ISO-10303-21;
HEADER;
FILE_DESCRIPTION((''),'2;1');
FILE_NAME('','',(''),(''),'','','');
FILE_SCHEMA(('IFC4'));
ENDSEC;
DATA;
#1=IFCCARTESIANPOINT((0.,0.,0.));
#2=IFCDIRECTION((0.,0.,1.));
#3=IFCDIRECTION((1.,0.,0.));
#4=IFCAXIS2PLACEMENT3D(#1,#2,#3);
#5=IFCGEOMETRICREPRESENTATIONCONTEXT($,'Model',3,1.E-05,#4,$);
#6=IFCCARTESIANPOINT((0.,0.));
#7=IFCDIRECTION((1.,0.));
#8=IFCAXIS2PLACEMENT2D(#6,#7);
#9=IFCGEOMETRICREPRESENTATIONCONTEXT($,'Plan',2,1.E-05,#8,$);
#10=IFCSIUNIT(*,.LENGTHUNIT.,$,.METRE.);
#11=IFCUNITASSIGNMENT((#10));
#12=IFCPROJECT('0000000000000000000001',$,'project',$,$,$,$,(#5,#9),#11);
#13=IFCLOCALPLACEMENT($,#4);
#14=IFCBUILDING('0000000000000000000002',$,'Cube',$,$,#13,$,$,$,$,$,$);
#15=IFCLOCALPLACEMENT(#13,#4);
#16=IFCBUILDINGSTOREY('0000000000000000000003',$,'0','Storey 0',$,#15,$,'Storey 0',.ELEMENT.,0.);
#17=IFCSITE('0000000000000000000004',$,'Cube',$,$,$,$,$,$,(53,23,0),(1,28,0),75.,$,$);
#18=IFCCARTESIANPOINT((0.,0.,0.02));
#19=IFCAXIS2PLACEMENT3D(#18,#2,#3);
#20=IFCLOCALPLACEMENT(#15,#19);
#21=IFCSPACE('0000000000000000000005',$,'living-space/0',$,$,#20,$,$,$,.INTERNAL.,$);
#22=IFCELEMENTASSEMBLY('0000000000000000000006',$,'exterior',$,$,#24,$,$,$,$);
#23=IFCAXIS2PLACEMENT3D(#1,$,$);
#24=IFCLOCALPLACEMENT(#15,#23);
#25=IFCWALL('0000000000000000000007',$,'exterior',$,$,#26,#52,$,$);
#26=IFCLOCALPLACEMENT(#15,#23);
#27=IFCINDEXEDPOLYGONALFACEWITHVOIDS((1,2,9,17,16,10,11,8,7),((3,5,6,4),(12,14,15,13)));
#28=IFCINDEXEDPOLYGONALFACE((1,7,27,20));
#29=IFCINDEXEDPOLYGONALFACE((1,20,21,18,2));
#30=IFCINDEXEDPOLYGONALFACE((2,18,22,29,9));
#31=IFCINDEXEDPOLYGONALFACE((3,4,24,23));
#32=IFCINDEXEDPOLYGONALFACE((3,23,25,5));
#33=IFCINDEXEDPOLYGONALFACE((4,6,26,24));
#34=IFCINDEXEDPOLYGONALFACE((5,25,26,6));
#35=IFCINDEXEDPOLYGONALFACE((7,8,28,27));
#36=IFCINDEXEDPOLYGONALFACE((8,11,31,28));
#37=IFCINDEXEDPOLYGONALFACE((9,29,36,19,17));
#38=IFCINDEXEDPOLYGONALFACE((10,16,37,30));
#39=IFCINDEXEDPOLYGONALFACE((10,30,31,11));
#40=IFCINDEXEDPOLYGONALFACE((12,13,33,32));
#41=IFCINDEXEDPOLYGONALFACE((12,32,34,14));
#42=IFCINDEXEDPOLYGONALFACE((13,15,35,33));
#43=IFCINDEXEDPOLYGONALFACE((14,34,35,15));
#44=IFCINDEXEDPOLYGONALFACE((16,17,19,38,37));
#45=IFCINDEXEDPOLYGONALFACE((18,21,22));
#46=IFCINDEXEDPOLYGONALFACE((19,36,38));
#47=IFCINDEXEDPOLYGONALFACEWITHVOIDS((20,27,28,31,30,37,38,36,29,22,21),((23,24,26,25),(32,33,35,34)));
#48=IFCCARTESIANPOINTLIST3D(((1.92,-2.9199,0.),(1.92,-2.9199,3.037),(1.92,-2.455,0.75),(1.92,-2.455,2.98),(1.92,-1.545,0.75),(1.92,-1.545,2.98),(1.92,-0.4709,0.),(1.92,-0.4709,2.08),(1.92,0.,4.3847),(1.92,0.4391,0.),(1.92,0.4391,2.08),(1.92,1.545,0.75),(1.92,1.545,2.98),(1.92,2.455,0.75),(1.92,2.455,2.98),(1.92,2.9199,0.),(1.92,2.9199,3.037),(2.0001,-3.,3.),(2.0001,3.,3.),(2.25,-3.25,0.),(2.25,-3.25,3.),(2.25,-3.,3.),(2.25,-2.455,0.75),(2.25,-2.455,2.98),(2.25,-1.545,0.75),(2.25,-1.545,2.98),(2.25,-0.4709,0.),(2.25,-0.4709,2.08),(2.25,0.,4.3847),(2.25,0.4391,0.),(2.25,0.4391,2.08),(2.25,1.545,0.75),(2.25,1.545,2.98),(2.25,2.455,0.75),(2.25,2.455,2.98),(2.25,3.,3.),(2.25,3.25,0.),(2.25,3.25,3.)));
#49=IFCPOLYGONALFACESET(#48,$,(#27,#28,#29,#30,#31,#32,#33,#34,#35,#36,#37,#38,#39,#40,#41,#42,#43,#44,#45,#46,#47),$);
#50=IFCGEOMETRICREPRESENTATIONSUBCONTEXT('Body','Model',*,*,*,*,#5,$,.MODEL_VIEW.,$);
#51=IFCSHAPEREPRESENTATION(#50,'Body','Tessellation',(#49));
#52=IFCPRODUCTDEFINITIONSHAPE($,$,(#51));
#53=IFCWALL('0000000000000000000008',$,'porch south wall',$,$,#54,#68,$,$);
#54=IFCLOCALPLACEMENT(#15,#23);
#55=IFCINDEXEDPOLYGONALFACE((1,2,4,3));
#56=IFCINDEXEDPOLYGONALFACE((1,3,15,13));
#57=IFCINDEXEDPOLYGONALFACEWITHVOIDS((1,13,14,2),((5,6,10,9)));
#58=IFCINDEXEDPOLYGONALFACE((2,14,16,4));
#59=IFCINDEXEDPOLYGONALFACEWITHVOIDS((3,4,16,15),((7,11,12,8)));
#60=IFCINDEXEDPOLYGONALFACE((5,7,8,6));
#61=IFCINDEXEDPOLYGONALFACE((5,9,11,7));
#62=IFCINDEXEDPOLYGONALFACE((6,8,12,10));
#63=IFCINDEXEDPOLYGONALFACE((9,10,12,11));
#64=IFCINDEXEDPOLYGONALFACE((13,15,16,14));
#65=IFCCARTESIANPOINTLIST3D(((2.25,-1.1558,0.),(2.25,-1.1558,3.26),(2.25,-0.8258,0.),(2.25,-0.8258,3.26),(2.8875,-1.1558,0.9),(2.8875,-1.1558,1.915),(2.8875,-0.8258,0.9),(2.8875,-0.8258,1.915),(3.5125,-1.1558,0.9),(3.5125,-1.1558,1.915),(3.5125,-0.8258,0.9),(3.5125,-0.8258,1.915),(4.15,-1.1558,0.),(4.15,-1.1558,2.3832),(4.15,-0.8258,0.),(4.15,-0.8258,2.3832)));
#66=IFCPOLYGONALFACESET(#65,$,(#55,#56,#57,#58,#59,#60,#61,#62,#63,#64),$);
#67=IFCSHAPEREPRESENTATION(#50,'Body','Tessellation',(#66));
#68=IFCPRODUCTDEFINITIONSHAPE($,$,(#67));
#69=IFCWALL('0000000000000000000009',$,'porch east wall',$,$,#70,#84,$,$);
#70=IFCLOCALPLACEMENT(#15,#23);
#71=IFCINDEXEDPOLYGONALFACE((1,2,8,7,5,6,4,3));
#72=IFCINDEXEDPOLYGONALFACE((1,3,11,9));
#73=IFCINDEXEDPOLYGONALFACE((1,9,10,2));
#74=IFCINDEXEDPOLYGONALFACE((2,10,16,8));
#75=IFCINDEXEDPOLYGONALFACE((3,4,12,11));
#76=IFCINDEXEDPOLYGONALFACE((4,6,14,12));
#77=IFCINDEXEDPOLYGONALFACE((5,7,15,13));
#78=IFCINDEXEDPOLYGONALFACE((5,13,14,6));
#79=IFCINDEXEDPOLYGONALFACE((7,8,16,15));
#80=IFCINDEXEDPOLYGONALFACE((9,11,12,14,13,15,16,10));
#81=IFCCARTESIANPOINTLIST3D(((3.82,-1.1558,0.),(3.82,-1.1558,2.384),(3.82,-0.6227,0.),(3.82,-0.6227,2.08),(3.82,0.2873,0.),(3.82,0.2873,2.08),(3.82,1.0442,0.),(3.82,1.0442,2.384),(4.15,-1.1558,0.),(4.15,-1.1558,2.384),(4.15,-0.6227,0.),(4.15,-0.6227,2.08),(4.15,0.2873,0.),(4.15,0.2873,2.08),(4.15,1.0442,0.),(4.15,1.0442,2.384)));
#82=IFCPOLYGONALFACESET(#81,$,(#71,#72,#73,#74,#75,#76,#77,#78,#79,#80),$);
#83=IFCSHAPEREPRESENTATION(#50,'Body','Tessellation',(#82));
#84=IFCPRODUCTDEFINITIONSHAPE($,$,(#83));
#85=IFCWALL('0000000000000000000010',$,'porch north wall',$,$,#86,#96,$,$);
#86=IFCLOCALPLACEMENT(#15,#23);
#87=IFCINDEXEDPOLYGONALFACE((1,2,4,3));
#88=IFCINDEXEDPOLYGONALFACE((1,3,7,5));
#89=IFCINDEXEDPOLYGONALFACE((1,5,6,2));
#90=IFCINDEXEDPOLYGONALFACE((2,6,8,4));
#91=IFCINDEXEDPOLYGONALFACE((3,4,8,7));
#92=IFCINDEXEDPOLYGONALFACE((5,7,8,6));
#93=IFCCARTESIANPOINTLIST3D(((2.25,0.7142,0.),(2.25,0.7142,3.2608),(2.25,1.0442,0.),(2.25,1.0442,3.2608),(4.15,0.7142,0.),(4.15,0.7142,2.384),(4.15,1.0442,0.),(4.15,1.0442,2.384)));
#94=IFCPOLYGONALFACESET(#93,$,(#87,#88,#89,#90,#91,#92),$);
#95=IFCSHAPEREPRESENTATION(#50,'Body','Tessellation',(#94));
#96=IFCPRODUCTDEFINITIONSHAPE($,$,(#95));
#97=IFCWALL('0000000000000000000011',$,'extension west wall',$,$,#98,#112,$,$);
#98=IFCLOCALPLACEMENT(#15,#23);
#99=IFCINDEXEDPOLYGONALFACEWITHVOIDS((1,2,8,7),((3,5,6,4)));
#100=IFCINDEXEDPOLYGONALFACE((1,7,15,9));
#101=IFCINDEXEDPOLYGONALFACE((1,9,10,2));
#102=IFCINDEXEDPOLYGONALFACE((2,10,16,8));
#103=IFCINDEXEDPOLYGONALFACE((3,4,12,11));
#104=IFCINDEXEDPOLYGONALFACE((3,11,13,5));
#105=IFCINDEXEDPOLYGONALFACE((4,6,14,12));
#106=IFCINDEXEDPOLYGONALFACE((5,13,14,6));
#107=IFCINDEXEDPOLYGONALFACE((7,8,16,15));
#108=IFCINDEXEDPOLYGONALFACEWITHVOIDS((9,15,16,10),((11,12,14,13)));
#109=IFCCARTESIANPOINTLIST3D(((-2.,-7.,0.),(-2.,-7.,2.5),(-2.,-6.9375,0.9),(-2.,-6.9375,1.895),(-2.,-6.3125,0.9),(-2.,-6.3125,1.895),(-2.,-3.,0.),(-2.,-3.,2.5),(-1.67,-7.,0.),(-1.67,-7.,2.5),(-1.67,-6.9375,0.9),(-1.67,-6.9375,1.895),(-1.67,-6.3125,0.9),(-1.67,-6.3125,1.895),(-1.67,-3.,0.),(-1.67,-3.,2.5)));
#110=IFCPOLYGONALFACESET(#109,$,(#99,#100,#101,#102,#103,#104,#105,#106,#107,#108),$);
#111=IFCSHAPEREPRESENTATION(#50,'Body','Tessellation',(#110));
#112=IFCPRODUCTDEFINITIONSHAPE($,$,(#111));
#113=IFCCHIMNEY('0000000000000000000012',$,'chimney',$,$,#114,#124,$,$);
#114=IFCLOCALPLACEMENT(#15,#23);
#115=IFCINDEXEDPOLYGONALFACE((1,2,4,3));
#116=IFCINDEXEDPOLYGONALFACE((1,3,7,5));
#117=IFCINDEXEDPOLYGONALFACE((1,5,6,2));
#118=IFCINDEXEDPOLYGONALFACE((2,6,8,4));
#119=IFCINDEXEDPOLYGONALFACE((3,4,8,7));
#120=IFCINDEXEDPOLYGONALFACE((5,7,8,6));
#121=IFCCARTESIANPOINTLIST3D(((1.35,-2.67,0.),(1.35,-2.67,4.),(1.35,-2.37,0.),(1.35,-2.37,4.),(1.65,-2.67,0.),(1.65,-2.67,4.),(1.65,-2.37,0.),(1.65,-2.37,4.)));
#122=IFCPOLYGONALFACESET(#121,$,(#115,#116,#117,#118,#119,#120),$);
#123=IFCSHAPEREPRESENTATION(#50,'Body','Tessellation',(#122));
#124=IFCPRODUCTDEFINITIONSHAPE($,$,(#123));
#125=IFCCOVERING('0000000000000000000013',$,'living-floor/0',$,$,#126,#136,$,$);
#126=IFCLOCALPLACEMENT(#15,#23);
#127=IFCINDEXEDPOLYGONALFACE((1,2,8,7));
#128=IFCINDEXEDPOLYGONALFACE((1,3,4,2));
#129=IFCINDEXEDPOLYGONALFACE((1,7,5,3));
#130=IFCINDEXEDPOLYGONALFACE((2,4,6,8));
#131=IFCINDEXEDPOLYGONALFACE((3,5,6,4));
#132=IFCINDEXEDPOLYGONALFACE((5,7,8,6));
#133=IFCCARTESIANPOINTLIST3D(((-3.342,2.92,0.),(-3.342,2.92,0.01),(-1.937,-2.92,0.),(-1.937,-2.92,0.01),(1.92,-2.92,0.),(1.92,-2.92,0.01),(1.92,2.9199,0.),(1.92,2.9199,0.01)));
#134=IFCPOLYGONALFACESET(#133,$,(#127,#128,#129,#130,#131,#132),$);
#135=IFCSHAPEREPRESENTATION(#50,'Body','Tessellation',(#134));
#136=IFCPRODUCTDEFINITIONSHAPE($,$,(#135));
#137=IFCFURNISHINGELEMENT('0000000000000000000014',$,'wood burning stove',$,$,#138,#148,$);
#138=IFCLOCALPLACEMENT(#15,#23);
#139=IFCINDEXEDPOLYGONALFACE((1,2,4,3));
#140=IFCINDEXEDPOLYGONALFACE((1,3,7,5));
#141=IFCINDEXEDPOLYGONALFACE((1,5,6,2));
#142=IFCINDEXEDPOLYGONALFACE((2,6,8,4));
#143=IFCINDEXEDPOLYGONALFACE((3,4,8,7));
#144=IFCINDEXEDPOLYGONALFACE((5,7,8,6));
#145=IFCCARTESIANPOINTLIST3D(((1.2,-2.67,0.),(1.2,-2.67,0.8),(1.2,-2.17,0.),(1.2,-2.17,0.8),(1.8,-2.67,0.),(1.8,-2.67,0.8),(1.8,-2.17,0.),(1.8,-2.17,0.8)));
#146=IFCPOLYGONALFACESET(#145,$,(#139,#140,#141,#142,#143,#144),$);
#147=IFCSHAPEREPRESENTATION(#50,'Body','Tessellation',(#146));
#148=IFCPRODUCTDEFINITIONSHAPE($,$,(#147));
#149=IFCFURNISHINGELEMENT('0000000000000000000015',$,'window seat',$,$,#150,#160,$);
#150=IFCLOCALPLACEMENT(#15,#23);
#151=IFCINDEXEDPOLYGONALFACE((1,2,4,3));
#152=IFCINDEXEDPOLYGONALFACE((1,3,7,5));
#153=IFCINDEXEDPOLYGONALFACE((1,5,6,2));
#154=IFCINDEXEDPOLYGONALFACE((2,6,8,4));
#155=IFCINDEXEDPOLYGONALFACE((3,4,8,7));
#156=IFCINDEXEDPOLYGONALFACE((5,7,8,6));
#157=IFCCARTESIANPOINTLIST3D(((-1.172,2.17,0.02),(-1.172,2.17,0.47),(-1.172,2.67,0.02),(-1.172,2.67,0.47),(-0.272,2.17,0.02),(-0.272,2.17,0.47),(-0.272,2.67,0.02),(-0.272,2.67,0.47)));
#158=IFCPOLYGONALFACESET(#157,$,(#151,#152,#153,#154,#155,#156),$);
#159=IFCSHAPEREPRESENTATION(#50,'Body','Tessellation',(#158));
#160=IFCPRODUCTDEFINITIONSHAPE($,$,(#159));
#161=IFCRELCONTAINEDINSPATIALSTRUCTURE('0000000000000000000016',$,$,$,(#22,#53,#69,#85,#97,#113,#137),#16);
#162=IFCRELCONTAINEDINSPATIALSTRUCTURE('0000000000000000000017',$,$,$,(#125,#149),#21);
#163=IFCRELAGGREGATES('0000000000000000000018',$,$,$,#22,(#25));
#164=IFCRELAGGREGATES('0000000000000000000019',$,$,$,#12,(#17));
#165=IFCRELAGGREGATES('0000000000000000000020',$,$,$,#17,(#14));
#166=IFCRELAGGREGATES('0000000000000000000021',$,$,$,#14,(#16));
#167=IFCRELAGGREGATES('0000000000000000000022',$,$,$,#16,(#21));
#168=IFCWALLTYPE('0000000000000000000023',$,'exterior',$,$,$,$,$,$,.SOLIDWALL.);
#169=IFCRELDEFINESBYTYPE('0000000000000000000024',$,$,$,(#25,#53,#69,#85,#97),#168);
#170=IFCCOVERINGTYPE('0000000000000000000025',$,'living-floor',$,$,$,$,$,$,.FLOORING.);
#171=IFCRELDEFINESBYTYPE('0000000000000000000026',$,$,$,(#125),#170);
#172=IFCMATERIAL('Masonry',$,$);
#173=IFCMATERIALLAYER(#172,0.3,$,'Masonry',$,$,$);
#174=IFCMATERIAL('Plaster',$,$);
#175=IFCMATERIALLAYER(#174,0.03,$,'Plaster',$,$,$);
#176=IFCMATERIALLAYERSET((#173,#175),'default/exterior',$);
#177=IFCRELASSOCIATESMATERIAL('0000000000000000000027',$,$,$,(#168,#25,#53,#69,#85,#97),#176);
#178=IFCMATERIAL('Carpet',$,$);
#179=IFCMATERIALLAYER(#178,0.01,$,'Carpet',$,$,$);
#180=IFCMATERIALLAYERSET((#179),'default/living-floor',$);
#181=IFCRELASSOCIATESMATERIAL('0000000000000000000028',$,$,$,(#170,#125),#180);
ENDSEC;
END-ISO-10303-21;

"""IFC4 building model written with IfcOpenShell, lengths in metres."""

from ifc_helpers import new_model, si_unit, frame, origin, origin_with_axes, origin_2d_with_axis, place, context, subcontext, project, spatial, polyline, line, indexed_curve, outline, extrude, clip, halfspace, bounded_halfspace, source, transform, mapped, material, layer, layer_set, layer_usage, type_object, element, aggregate, save


model = new_model("IFC4")

# Units and contexts
model_context = context("Model", 3, precision=1e-05, world=origin_with_axes())
plan_context = context("Plan", 2, precision=1e-05, world=origin_2d_with_axis())
body_context = subcontext(model_context, "Body", "Model", "MODEL_VIEW")
ifc_project = project(units=[si_unit("LENGTHUNIT", "METRE")], contexts=[model_context, plan_context])

# Site, building, storey
site = spatial("IfcSite", under=ifc_project, Name="Cube", RefLatitude=(53, 23, 0), RefLongitude=(1, 28, 0), RefElevation=75.0)
building_placement = place(None, origin_with_axes())
building = spatial("IfcBuilding", under=site, at=building_placement, Name="Cube")
storey_placement = place(building_placement, origin_with_axes())
storey = spatial("IfcBuildingStorey", under=building, at=storey_placement, Name="0", Description="Storey 0", LongName="Storey 0", CompositionType="ELEMENT", Elevation=0.0)

# Element assembly, wall, openings
ifc_material_1 = material(Name="Masonry")
ifc_layer_1 = layer(ifc_material_1, 0.3, Name="Masonry")
ifc_material_2 = material(Name="Plaster")
ifc_layer_2 = layer(ifc_material_2, 0.03, Name="Plaster")
ifc_layer_set_1 = layer_set([ifc_layer_1, ifc_layer_2], Name="default/exterior")
wall_type = type_object("IfcWallType", Name="exterior", PredefinedType="SOLIDWALL", material=ifc_layer_set_1)
assembly_1_placement = place(storey_placement, frame((2.0, -3.0, 0.0), z_axis=(0.0, 0.0, 1.0), x_axis=(0.0, 1.0, 0.0)))
assembly_1 = element("IfcElementAssembly", 1, at=assembly_1_placement, inside=storey, Name="exterior")
ifc_layer_usage_1 = layer_usage(ifc_layer_set_1, "AXIS2", "POSITIVE", -0.25)
wall_1_placement = place(assembly_1_placement, origin_with_axes())
wall_1 = element("IfcWall", 2, at=wall_1_placement, type_object=wall_type, material=ifc_layer_usage_1, Name="exterior", context=body_context, shape_type="Clipping", body=[
    clip(clip(clip(clip(extrude(outline(polyline([(0.0801, 0.08), (-0.25, -0.25), (6.25, -0.25), (5.9199, 0.08), (0.0801, 0.08)])), origin(), (0.0, 0.0, 1.0), 4.385), bounded_halfspace(frame((6.0, 0.0, 3.0), z_axis=(0.419069, 0.0, 0.907954), x_axis=(0.0, -1.0, 0.0)), False, origin(), polyline([(6.0, -1.0), (3.0, -1.0), (3.0, 1.0), (6.0, 1.0), (6.0, -1.0)]))), bounded_halfspace(frame((6.0, 0.0, 3.0), z_axis=(0.0, 0.0, 1.0), x_axis=(0.0, 1.0, 0.0)), False, origin(), polyline([(6.0, 1.0), (7.0, 1.0), (7.0, -1.0), (6.0, -1.0), (6.0, 1.0)]))), bounded_halfspace(frame((3.0, 0.0, 4.3847), z_axis=(-0.419069, 0.0, 0.907954), x_axis=(0.0, -1.0, 0.0)), False, origin(), polyline([(3.0, -1.0), (0.0, -1.0), (0.0, 1.0), (3.0, 1.0), (3.0, -1.0)]))), bounded_halfspace(frame((0.0, 0.0, 3.0), z_axis=(0.0, 0.0, 1.0), x_axis=(0.0, -1.0, 0.0)), False, origin(), polyline([(0.0, -1.0), (-1.0, -1.0), (-1.0, 1.0), (0.0, 1.0), (0.0, -1.0)]))),
])
opening_1_placement = place(wall_1_placement, frame((0.545, -0.25, 0.75), z_axis=(0.0, 0.0, 1.0), x_axis=(1.0, 0.0, 0.0)))
element("IfcOpeningElement", 3, at=opening_1_placement, cuts=wall_1, PredefinedType="OPENING", context=body_context, shape_type="SweptSolid", body=[
    extrude(outline(polyline([(0.0, -0.02), (0.91, -0.02), (0.91, 0.35), (0.0, 0.35), (0.0, -0.02)])), origin(), (0.0, 0.0, 1.0), 2.23),
])
opening_2_placement = place(wall_1_placement, frame((4.545, -0.25, 0.75), z_axis=(0.0, 0.0, 1.0), x_axis=(1.0, 0.0, 0.0)))
element("IfcOpeningElement", 4, at=opening_2_placement, cuts=wall_1, PredefinedType="OPENING", context=body_context, shape_type="SweptSolid", body=[
    extrude(outline(polyline([(0.0, -0.02), (0.91, -0.02), (0.91, 0.35), (0.0, 0.35), (0.0, -0.02)])), origin(), (0.0, 0.0, 1.0), 2.23),
])
shared_shape_1 = source(origin_with_axes(), body_context, "Body", "SweptSolid", [
    extrude(outline(indexed_curve([(0.0, 0.0), (0.91, 0.0), (0.91, 2.08), (0.0, 2.08)], segments=[line(1, 2, 3, 4, 1)])), frame((0.0, -0.6, 0.0), z_axis=(0.0, -1.0, 0.0), x_axis=(1.0, 0.0, 0.0)), (0.0, 0.0, -1.0), 1.2),
])
opening_3_placement = place(wall_1_placement, frame((2.5291, -0.25, 0.0), z_axis=(0.0, 0.0, 1.0), x_axis=(1.0, 0.0, 0.0)))
element("IfcOpeningElement", 5, at=opening_3_placement, cuts=wall_1, PredefinedType="OPENING", context=body_context, shape_type="MappedRepresentation", body=[
    mapped(shared_shape_1, transform((0.0, 0.0, 0.0), x_axis=(1.0, 0.0, 0.0), y_axis=(0.0, 1.0, 0.0), z_axis=(0.0, 0.0, 1.0), scale=1.0)),
])
aggregate(assembly_1, [wall_1])

# Walls, openings
ifc_layer_usage_2 = layer_usage(ifc_layer_set_1, "AXIS2", "POSITIVE", 0.0)
wall_2_placement = place(storey_placement, frame((2.25, -1.1558, 0.0), z_axis=(0.0, 0.0, 1.0), x_axis=(1.0, 0.0, 0.0)))
wall_2 = element("IfcWall", 6, at=wall_2_placement, inside=storey, type_object=wall_type, material=ifc_layer_usage_2, Name="porch south wall", context=body_context, shape_type="Clipping", body=[
    clip(extrude(outline(indexed_curve([(0.0, 0.0), (0.0, 0.33), (1.9, 0.33), (1.9, 0.0), (0.0, 0.0)], self_intersect=False)), origin_with_axes(), (0.0, 0.0, 1.0), 3.5), halfspace(frame((0.0, 0.0, 3.26), z_axis=(0.419, 0.0, 0.908), x_axis=(0.0, 1.0, 0.0)), False)),
])
opening_4_placement = place(wall_2_placement, frame((0.6375, -0.0002, 0.9), z_axis=(0.0, 0.0, 1.0), x_axis=(1.0, 0.0, 0.0)))
element("IfcOpeningElement", 7, at=opening_4_placement, cuts=wall_2, context=body_context, shape_type="SweptSolid", body=[
    extrude(outline(indexed_curve([(0.0, 0.0), (0.0, 0.5), (0.625, 0.5), (0.625, 0.0), (0.0, 0.0)], self_intersect=False)), origin_with_axes(), (0.0, 0.0, 1.0), 1.015),
])
ifc_layer_usage_3 = layer_usage(ifc_layer_set_1, "AXIS2", "POSITIVE", 0.0)
wall_3_placement = place(storey_placement, frame((4.15, -1.1558, 0.0), z_axis=(0.0, 0.0, 1.0), x_axis=(0.0, 1.0, 0.0)))
wall_3 = element("IfcWall", 8, at=wall_3_placement, inside=storey, type_object=wall_type, material=ifc_layer_usage_3, Name="porch east wall", context=body_context, shape_type="SweptSolid", body=[
    extrude(outline(indexed_curve([(0.0, 0.0), (0.0, 0.33), (2.2, 0.33), (2.2, 0.0), (0.0, 0.0)], self_intersect=False)), origin_with_axes(), (0.0, 0.0, 1.0), 2.384),
])
shared_shape_2 = source(origin_with_axes(), body_context, "Body", "SweptSolid", [
    extrude(outline(indexed_curve([(0.0, 0.0), (0.91, 0.0), (0.91, 2.08), (0.0, 2.08)], segments=[line(1, 2, 3, 4, 1)])), frame((0.0, -0.6, 0.0), z_axis=(0.0, -1.0, 0.0), x_axis=(1.0, 0.0, 0.0)), (0.0, 0.0, -1.0), 1.2),
])
opening_5_placement = place(wall_3_placement, frame((0.5331, 0.0, 0.0), z_axis=(0.0, 0.0, 1.0), x_axis=(1.0, 0.0, 0.0)))
element("IfcOpeningElement", 9, at=opening_5_placement, cuts=wall_3, PredefinedType="OPENING", context=body_context, shape_type="MappedRepresentation", body=[
    mapped(shared_shape_2, transform((0.0, 0.0, 0.0), x_axis=(1.0, 0.0, 0.0), y_axis=(0.0, 1.0, 0.0), z_axis=(0.0, 0.0, 1.0), scale=1.0)),
])

# Wall
ifc_layer_usage_4 = layer_usage(ifc_layer_set_1, "AXIS2", "POSITIVE", 0.0)
wall_4_placement = place(storey_placement, frame((4.15, 1.0442, 0.0), z_axis=(0.0, 0.0, 1.0), x_axis=(-1.0, 0.0, 0.0)))
element("IfcWall", 10, at=wall_4_placement, inside=storey, type_object=wall_type, material=ifc_layer_usage_4, Name="porch north wall", context=body_context, shape_type="Clipping", body=[
    clip(extrude(outline(indexed_curve([(0.0, 0.0), (0.0, 0.33), (1.9, 0.33), (1.9, 0.0), (0.0, 0.0)], self_intersect=False)), origin_with_axes(), (0.0, 0.0, 1.0), 3.5), halfspace(frame((0.0, 0.0, 2.384), z_axis=(-0.419, 0.0, 0.908), x_axis=(0.0, -1.0, 0.0)), False)),
])

# Wall, opening
ifc_layer_usage_5 = layer_usage(ifc_layer_set_1, "AXIS2", "POSITIVE", 0.0)
wall_5_placement = place(storey_placement, frame((-2.0, -3.0, 0.0), z_axis=(0.0, 0.0, 1.0), x_axis=(0.0, -1.0, 0.0)))
wall_5 = element("IfcWall", 11, at=wall_5_placement, inside=storey, type_object=wall_type, material=ifc_layer_usage_5, Name="extension west wall", context=body_context, shape_type="SweptSolid", body=[
    extrude(outline(indexed_curve([(0.0, 0.0), (0.0, 0.33), (4.0, 0.33), (4.0, 0.0), (0.0, 0.0)], self_intersect=False)), origin_with_axes(), (0.0, 0.0, 1.0), 2.5),
])
opening_6_placement = place(wall_5_placement, frame((3.3125, 0.0, 0.9), z_axis=(0.0, 0.0, 1.0), x_axis=(1.0, 0.0, 0.0)))
element("IfcOpeningElement", 12, at=opening_6_placement, cuts=wall_5, PredefinedType="OPENING", context=body_context, shape_type="SweptSolid", body=[
    extrude(outline(indexed_curve([(0.0, 0.0), (0.0, 0.5), (0.625, 0.5), (0.625, 0.0), (0.0, 0.0)], self_intersect=False)), origin_with_axes(), (0.0, 0.0, 1.0), 0.995),
])

# Chimney
chimney_placement = place(storey_placement, frame((1.35, -2.67, 0.0), z_axis=(0.0, 0.0, 1.0), x_axis=(1.0, 0.0, 0.0)))
element("IfcChimney", 13, at=chimney_placement, inside=storey, Name="chimney", context=body_context, shape_type="SweptSolid", body=[
    extrude(outline(indexed_curve([(0.0, 0.0), (0.3, 0.0), (0.3, 0.3), (0.0, 0.3)])), None, (0.0, 0.0, 1.0), 4.0),
])

# Shared definitions
space_placement = place(storey_placement, frame((0.0, 0.0, 0.02), z_axis=(0.0, 0.0, 1.0), x_axis=(1.0, 0.0, 0.0)))
space = spatial("IfcSpace", under=storey, at=space_placement, Name="living-space/0", PredefinedType="INTERNAL")

# Covering
ifc_material_3 = material(Name="Carpet")
ifc_layer_3 = layer(ifc_material_3, 0.01, Name="Carpet")
ifc_layer_set_2 = layer_set([ifc_layer_3], Name="default/living-floor")
ifc_layer_usage_6 = layer_usage(ifc_layer_set_2, "AXIS3", "POSITIVE", 0.0)
covering_type = type_object("IfcCoveringType", Name="living-floor", PredefinedType="FLOORING", material=ifc_layer_set_2)
covering_placement = place(space_placement, frame((0.0, 0.0, -0.02), z_axis=(0.0, 0.0, 1.0), x_axis=(1.0, 0.0, 0.0)))
element("IfcCovering", 14, at=covering_placement, inside=space, type_object=covering_type, material=ifc_layer_usage_6, Name="living-floor/0", context=body_context, shape_type="SweptSolid", body=[
    extrude(outline(polyline([(1.92, 2.9199), (-3.342, 2.92), (-1.937, -2.92), (1.92, -2.92), (1.92, 2.9199)])), origin_with_axes(), (0.0, 0.0, 1.0), 0.01),
])

# Furnishing elements
furnishing_1_placement = place(storey_placement, frame((1.2, -2.67, 0.0), z_axis=(0.0, 0.0, 1.0), x_axis=(1.0, 0.0, 0.0)))
element("IfcFurnishingElement", 15, at=furnishing_1_placement, inside=storey, Name="wood burning stove", context=body_context, shape_type="SweptSolid", body=[
    extrude(outline(indexed_curve([(0.0, 0.0), (0.6, 0.0), (0.6, 0.5), (0.0, 0.5)])), None, (0.0, 0.0, 1.0), 0.8),
])
furnishing_2_placement = place(space_placement, frame((-1.172, 2.17, 0.0), z_axis=(0.0, 0.0, 1.0), x_axis=(1.0, 0.0, 0.0)))
element("IfcFurnishingElement", 16, at=furnishing_2_placement, inside=space, Name="window seat", context=body_context, shape_type="SweptSolid", body=[
    extrude(outline(indexed_curve([(0.0, 0.0), (0.9, 0.0), (0.9, 0.5), (0.0, 0.5)])), None, (0.0, 0.0, 1.0), 0.45),
])

save(model, "model.ifc")
